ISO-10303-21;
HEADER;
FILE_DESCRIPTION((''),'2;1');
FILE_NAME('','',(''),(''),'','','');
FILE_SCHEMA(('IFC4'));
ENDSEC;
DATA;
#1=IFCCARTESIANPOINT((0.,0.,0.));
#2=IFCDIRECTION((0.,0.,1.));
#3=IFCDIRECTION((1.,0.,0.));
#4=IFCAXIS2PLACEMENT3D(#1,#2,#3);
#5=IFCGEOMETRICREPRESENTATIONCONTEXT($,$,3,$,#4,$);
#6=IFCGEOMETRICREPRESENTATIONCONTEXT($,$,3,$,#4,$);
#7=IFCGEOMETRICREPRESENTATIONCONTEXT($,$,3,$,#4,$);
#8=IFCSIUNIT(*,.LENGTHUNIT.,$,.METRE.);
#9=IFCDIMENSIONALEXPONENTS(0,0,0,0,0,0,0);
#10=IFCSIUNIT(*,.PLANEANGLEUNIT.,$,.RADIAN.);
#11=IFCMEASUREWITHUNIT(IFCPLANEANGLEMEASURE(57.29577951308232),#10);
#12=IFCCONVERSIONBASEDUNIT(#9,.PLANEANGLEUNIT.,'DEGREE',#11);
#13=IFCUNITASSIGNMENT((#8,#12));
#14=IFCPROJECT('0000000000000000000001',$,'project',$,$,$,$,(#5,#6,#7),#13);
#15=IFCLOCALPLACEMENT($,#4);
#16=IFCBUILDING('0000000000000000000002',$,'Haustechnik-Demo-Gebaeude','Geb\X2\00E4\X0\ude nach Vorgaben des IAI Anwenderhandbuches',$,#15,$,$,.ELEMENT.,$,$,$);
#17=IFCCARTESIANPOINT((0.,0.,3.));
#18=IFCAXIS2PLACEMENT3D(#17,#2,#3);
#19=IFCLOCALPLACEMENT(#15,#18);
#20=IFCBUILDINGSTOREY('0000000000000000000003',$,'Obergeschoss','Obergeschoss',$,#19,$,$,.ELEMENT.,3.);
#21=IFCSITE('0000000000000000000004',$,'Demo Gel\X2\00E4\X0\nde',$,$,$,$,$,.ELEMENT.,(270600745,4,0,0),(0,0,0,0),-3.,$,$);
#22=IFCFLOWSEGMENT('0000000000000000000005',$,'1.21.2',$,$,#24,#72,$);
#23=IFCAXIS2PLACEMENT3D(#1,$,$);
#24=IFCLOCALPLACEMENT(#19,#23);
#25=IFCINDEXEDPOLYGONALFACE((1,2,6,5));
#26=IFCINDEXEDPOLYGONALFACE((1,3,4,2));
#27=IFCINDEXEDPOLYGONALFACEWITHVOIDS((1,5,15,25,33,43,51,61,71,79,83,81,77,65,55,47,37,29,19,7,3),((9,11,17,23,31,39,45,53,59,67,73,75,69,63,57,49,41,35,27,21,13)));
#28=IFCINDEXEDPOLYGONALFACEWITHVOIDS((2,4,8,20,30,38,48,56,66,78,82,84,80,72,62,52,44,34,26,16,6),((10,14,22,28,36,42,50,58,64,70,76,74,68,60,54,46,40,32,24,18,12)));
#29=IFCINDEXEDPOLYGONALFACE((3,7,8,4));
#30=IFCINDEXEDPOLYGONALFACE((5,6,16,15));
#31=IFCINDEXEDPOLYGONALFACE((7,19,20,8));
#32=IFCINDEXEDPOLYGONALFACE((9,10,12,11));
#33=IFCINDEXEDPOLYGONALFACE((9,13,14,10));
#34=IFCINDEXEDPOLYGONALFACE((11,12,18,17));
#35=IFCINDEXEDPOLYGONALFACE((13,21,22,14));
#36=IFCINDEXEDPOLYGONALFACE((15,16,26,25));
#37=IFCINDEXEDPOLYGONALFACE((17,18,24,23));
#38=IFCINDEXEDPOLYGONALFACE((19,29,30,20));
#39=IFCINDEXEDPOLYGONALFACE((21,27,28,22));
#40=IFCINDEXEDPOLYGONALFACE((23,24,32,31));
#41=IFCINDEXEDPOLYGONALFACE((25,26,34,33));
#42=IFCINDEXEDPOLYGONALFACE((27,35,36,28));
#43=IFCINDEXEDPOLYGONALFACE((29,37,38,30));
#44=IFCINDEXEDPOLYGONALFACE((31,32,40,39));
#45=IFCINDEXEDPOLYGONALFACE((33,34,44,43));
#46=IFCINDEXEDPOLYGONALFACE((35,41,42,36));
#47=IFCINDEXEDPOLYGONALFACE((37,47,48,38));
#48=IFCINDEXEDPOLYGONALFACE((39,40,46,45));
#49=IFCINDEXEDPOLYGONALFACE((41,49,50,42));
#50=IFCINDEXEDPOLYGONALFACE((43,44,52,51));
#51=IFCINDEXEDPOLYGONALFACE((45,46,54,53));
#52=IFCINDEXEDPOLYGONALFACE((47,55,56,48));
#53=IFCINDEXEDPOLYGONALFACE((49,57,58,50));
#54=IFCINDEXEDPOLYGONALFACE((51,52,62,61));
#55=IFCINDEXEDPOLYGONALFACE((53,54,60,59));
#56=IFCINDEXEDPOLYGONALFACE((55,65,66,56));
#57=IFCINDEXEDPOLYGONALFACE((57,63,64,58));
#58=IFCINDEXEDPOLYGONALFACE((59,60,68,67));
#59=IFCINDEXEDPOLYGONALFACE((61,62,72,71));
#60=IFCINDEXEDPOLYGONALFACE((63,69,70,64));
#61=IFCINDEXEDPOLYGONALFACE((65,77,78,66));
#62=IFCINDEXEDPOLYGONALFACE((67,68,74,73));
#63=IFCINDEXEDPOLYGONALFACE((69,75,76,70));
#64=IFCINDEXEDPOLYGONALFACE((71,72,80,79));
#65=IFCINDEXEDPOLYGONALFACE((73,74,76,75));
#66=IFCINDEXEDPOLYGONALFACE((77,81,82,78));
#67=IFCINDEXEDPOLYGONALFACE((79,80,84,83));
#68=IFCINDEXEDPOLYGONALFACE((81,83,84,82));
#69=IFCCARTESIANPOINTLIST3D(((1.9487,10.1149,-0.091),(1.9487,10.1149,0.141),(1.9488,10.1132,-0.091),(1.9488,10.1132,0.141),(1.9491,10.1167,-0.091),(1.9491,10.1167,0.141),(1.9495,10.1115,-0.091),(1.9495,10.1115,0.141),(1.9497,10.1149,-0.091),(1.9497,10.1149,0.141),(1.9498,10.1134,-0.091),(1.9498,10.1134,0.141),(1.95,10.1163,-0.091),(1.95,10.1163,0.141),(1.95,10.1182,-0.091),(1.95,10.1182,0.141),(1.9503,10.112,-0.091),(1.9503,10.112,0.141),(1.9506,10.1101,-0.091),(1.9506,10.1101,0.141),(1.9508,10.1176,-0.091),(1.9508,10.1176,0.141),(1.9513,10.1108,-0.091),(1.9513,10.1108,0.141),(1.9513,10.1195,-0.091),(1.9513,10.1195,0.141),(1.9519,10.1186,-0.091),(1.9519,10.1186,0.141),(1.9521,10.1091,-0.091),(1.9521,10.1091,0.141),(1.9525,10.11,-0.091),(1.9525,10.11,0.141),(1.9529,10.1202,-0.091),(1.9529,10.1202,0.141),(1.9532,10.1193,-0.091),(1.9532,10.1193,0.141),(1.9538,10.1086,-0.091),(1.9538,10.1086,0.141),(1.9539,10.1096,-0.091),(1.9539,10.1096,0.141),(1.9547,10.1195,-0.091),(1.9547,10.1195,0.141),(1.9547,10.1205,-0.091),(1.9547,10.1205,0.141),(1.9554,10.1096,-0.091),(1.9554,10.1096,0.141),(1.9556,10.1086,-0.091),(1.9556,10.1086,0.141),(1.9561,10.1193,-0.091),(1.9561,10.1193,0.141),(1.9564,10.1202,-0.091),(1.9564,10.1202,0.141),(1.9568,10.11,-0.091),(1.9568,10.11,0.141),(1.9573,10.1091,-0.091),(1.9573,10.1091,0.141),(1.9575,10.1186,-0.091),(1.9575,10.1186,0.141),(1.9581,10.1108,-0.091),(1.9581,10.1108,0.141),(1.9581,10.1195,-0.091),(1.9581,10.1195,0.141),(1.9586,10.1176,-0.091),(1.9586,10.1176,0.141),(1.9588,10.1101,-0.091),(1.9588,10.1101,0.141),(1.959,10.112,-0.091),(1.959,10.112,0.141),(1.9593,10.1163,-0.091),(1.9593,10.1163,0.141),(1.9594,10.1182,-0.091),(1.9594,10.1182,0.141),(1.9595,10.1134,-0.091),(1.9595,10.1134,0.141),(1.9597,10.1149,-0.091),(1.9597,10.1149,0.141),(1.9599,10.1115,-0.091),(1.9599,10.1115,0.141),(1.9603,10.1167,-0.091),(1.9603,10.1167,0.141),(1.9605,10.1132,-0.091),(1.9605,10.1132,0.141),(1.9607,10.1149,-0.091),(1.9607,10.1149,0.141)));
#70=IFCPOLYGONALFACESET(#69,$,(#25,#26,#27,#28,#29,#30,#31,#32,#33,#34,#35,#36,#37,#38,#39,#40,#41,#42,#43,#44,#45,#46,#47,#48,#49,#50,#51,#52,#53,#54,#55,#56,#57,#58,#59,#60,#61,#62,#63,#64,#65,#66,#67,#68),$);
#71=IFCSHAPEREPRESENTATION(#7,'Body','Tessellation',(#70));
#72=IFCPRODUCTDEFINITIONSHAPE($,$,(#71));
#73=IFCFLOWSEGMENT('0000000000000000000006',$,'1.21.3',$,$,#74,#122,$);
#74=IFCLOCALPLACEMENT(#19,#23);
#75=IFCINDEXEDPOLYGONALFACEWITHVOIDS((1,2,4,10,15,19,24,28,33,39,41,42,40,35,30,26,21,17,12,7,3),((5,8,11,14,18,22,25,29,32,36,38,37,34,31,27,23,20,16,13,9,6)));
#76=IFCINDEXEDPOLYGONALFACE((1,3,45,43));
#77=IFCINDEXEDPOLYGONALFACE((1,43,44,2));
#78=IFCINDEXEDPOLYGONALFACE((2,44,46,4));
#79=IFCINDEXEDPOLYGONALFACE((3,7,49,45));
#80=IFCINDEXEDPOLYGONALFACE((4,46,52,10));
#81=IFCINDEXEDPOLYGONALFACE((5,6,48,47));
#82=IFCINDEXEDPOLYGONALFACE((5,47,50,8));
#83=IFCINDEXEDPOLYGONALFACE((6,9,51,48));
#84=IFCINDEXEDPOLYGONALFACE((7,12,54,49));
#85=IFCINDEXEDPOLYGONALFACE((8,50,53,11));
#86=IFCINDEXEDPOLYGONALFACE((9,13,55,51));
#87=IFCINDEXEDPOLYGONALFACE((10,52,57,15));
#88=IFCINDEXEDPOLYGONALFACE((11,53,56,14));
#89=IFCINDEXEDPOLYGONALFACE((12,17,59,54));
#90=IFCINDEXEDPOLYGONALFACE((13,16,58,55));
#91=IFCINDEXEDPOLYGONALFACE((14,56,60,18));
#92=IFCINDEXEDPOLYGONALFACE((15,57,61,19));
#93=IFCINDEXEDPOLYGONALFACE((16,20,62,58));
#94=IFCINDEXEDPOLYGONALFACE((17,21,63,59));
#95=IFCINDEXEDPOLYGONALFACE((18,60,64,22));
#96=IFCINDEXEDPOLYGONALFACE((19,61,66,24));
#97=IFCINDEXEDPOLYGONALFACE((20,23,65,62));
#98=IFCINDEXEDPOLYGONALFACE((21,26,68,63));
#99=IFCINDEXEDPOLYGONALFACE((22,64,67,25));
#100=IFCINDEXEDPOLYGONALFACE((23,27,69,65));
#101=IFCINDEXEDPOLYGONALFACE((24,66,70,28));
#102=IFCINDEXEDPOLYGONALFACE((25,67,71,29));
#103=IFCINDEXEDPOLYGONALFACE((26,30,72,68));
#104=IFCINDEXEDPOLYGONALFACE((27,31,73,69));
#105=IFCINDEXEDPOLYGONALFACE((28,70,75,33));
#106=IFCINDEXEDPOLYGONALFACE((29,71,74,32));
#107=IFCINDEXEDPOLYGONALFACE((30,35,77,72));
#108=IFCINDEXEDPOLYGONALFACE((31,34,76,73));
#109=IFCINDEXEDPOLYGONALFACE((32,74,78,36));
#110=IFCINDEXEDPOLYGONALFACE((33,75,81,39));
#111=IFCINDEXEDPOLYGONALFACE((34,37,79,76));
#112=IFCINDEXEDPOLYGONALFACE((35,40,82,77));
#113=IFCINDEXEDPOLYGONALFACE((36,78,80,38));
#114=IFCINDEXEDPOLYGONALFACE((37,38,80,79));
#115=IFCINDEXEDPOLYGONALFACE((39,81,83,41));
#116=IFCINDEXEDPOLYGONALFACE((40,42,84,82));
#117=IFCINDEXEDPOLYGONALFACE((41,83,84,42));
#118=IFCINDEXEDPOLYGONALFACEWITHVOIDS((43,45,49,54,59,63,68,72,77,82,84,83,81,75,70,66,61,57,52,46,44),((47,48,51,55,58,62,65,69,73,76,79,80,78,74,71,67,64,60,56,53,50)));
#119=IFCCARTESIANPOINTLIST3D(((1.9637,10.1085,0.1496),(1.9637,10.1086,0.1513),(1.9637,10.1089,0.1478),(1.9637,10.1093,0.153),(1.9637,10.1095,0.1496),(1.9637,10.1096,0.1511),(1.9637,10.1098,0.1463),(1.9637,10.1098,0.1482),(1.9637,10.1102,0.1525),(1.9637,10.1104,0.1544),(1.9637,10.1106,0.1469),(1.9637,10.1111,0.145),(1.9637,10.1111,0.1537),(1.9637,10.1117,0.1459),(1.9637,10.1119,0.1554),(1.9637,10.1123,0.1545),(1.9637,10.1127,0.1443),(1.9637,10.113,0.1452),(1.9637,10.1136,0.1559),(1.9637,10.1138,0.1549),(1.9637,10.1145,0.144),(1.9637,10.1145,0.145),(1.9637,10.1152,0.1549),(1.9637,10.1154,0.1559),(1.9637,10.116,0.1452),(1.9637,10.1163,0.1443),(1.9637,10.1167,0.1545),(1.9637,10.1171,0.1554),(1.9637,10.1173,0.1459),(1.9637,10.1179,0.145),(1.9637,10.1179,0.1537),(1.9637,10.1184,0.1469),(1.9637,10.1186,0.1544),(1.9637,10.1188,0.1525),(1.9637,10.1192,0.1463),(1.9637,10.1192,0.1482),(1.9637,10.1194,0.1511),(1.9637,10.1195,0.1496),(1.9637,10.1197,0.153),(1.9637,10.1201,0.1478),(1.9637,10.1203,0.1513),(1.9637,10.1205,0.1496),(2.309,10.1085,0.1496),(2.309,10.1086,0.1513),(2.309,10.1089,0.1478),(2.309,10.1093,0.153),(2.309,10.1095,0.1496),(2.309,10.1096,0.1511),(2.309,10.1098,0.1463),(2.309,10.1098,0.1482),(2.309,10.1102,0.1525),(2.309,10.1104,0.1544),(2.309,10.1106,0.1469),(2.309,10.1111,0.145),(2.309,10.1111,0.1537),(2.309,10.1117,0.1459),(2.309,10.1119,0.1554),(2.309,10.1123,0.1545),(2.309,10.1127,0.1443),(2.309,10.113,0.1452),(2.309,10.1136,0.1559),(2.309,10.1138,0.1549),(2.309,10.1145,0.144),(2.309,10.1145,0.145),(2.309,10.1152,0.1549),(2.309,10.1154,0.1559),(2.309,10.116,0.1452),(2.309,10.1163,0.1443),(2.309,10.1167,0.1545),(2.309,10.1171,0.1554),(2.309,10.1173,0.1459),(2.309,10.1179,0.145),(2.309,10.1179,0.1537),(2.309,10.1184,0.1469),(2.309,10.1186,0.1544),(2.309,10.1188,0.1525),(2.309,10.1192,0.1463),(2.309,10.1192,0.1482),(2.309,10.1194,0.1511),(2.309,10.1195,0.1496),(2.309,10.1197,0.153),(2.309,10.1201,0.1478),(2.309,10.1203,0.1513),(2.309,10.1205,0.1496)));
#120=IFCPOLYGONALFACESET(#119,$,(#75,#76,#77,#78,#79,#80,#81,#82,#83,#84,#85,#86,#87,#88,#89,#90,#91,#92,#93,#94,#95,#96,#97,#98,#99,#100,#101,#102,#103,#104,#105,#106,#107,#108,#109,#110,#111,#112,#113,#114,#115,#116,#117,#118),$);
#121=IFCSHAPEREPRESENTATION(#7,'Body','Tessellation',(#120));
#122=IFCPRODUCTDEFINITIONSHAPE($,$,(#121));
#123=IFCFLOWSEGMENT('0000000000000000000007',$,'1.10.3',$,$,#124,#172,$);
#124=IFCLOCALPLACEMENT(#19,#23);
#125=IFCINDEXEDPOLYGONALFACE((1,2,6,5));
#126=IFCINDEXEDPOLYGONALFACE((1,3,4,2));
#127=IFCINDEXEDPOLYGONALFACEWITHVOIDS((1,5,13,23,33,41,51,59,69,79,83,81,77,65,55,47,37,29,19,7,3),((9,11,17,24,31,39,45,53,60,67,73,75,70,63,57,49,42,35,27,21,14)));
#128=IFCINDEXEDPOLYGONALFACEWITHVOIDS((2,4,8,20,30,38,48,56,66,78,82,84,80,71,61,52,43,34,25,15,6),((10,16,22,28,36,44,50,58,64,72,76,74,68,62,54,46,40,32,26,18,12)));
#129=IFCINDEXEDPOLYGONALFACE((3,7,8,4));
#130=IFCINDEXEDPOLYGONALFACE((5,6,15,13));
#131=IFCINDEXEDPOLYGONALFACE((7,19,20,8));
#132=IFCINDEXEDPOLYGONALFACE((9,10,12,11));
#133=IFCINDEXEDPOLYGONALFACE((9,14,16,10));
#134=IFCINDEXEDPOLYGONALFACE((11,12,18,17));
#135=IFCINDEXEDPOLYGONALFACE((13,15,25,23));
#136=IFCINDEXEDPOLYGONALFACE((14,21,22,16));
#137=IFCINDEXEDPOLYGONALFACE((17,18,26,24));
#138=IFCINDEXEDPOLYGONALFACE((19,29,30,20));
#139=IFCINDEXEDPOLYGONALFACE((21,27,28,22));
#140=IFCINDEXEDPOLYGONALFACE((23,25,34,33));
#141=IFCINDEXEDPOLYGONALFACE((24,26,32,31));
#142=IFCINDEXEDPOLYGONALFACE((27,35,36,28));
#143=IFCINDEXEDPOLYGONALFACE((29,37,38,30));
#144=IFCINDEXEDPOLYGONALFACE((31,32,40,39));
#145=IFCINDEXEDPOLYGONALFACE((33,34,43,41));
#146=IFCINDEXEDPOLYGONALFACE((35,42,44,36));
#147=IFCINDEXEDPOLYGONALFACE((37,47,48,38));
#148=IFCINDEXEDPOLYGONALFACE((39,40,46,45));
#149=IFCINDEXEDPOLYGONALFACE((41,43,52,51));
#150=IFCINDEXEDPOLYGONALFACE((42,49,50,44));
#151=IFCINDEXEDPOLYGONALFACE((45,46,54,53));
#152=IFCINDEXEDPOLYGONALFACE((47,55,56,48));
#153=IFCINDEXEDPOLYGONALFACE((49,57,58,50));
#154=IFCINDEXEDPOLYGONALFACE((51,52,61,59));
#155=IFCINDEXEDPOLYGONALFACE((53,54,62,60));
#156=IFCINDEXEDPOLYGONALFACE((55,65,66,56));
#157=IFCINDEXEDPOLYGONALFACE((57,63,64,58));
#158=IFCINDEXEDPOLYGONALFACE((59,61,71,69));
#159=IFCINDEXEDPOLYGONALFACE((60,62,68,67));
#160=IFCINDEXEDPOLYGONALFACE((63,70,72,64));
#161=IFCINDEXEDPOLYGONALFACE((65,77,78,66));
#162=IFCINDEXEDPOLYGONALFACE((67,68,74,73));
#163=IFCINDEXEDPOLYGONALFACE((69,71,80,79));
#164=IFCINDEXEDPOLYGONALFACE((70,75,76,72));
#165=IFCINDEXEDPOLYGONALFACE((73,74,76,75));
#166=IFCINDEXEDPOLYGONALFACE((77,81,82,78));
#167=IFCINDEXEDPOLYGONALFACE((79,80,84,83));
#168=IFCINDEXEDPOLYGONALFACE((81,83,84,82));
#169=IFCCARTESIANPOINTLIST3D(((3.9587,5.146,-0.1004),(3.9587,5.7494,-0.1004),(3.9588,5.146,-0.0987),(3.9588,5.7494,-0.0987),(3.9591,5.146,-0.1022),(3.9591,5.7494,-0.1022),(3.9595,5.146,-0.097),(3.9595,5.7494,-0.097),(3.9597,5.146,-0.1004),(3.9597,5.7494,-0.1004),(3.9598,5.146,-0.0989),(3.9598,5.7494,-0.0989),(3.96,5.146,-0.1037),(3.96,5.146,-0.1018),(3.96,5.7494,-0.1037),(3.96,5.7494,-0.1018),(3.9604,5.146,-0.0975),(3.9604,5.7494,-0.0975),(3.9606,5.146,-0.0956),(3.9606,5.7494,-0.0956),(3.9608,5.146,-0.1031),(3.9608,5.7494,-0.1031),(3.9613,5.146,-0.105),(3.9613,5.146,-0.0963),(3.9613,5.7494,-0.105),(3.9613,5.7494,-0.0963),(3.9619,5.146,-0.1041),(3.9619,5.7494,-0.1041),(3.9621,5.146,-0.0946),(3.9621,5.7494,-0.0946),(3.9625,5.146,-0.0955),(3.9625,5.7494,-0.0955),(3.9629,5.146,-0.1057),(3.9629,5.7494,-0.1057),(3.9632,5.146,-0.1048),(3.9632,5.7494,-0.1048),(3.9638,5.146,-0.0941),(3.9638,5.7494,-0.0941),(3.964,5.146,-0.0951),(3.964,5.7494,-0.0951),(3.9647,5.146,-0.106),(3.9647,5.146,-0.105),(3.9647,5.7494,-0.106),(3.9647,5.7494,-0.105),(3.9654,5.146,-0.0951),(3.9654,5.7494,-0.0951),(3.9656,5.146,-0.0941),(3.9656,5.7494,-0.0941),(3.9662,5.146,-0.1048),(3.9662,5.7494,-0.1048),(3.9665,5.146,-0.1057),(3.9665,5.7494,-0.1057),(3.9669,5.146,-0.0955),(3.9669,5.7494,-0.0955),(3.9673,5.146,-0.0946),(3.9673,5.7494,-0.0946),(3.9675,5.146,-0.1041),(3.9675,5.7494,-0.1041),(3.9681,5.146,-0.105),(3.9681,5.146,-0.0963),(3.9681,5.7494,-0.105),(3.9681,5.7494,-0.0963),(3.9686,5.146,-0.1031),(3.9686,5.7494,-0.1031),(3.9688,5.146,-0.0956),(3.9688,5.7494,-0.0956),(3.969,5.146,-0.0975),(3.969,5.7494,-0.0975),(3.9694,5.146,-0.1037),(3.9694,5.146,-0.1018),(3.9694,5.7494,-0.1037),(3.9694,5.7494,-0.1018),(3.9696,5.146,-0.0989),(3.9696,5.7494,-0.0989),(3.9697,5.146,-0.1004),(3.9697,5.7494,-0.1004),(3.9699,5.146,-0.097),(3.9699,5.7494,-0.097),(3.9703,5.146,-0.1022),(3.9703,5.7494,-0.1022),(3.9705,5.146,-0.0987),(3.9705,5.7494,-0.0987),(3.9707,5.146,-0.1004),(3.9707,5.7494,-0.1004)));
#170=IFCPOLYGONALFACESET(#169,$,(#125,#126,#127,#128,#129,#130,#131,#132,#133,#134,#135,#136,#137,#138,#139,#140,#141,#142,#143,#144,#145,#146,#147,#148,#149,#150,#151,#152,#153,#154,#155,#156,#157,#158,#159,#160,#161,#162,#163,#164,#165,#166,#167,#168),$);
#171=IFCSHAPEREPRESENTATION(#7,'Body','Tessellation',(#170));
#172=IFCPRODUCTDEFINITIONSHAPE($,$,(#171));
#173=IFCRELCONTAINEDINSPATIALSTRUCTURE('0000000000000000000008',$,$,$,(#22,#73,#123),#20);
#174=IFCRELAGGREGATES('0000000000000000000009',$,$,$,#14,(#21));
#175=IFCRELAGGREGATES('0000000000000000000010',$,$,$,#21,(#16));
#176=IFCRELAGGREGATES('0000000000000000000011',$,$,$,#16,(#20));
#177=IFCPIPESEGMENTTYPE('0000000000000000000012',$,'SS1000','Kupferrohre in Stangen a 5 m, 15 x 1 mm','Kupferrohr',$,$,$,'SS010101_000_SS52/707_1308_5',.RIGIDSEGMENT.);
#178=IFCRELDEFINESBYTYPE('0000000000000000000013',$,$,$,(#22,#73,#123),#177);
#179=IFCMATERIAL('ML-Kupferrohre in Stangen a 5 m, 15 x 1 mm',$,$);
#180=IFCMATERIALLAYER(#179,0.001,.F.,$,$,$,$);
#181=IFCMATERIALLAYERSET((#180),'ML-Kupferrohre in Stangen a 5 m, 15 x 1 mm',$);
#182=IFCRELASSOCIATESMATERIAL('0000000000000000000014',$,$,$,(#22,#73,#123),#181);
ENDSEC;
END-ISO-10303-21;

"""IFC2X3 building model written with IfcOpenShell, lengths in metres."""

from ifc_helpers import new_model, entity, si_unit, converted_unit, frame, origin_with_axes, origin_2d_with_axis, place, context, project, spatial, hollow_circle, extrude, material, layer, layer_set, layer_usage, type_object, element, save


model = new_model("IFC2X3")

# Units and contexts
context_of_model_1 = context(None, 3, world=origin_with_axes())
context_of_model_2 = context(None, 3, world=origin_with_axes())
context_of_model_3 = context(None, 3, world=origin_with_axes())
ifc_project = project(units=[si_unit("LENGTHUNIT", "METRE"), converted_unit("PLANEANGLEUNIT", "DEGREE", entity("IfcPlaneAngleMeasure", 57.29577951308232), si_unit("PLANEANGLEUNIT", "RADIAN"), dimensions=[0, 0, 0, 0, 0, 0, 0])], contexts=[context_of_model_1, context_of_model_2, context_of_model_3])

# Site, building, storey
site = spatial("IfcSite", under=ifc_project, Name="Demo Gelände", CompositionType="ELEMENT", RefLatitude=(270600745, 4, 0, 0), RefLongitude=(0, 0, 0, 0), RefElevation=-3.0)
building_placement = place(None, origin_with_axes())
building = spatial("IfcBuilding", under=site, at=building_placement, Name="Haustechnik-Demo-Gebaeude", Description="Gebäude nach Vorgaben des IAI Anwenderhandbuches", CompositionType="ELEMENT")
storey_placement = place(building_placement, frame((0.0, 0.0, 3.0), z_axis=(0.0, 0.0, 1.0), x_axis=(1.0, 0.0, 0.0)))
storey = spatial("IfcBuildingStorey", under=building, at=storey_placement, Name="Obergeschoss", Description="Obergeschoss", CompositionType="ELEMENT", Elevation=3.0)

# Flow segments
ifc_material = material(Name="ML-Kupferrohre in Stangen a 5 m, 15 x 1 mm")
ifc_layer = layer(ifc_material, 0.001, ventilated=False)
ifc_layer_set = layer_set([ifc_layer], Name="ML-Kupferrohre in Stangen a 5 m, 15 x 1 mm")
ifc_layer_usage = layer_usage(ifc_layer_set, "AXIS2", "POSITIVE", 0.0)
pipe_segment_type_1 = type_object("IfcPipeSegmentType", Name="SS1000", Description="Kupferrohre in Stangen a 5 m, 15 x 1 mm", ApplicableOccurrence="Kupferrohr", ElementType="SS010101_000_SS52/707_1308_5", PredefinedType="RIGIDSEGMENT")
flow_segment_1_placement = place(storey_placement, frame((1.9547, 10.1145, -0.091), z_axis=(0.0, 0.0, 1.0), x_axis=(0.0, 1.0, 0.0)))
element("IfcFlowSegment", 1, at=flow_segment_1_placement, inside=storey, type_object=pipe_segment_type_1, material=ifc_layer_usage, Name="1.21.2", context=context_of_model_3, shape_type="SweptSolid", body=[
    extrude(hollow_circle(Radius=0.006, WallThickness=0.001, at=origin_2d_with_axis()), origin_with_axes(), (0.0, 0.0, 1.0), 0.232),
])
flow_segment_2_placement = place(storey_placement, frame((1.9637, 10.1145, 0.15), z_axis=(1.0, 0.0, 0.0), x_axis=(0.0, 0.0, -1.0)))
element("IfcFlowSegment", 2, at=flow_segment_2_placement, inside=storey, type_object=pipe_segment_type_1, material=ifc_layer_usage, Name="1.21.3", context=context_of_model_3, shape_type="SweptSolid", body=[
    extrude(hollow_circle(Radius=0.006, WallThickness=0.001, at=origin_2d_with_axis()), origin_with_axes(), (0.0, 0.0, 1.0), 0.3453),
])
flow_segment_3_placement = place(storey_placement, frame((3.9647, 5.7494, -0.1), z_axis=(0.0, -1.0, 0.0), x_axis=(0.0, 0.0, -1.0)))
element("IfcFlowSegment", 3, at=flow_segment_3_placement, inside=storey, type_object=pipe_segment_type_1, material=ifc_layer_usage, Name="1.10.3", context=context_of_model_3, shape_type="SweptSolid", body=[
    extrude(hollow_circle(Radius=0.006, WallThickness=0.001, at=origin_2d_with_axis()), origin_with_axes(), (0.0, 0.0, 1.0), 0.6034),
])

save(model, "model.ifc")
